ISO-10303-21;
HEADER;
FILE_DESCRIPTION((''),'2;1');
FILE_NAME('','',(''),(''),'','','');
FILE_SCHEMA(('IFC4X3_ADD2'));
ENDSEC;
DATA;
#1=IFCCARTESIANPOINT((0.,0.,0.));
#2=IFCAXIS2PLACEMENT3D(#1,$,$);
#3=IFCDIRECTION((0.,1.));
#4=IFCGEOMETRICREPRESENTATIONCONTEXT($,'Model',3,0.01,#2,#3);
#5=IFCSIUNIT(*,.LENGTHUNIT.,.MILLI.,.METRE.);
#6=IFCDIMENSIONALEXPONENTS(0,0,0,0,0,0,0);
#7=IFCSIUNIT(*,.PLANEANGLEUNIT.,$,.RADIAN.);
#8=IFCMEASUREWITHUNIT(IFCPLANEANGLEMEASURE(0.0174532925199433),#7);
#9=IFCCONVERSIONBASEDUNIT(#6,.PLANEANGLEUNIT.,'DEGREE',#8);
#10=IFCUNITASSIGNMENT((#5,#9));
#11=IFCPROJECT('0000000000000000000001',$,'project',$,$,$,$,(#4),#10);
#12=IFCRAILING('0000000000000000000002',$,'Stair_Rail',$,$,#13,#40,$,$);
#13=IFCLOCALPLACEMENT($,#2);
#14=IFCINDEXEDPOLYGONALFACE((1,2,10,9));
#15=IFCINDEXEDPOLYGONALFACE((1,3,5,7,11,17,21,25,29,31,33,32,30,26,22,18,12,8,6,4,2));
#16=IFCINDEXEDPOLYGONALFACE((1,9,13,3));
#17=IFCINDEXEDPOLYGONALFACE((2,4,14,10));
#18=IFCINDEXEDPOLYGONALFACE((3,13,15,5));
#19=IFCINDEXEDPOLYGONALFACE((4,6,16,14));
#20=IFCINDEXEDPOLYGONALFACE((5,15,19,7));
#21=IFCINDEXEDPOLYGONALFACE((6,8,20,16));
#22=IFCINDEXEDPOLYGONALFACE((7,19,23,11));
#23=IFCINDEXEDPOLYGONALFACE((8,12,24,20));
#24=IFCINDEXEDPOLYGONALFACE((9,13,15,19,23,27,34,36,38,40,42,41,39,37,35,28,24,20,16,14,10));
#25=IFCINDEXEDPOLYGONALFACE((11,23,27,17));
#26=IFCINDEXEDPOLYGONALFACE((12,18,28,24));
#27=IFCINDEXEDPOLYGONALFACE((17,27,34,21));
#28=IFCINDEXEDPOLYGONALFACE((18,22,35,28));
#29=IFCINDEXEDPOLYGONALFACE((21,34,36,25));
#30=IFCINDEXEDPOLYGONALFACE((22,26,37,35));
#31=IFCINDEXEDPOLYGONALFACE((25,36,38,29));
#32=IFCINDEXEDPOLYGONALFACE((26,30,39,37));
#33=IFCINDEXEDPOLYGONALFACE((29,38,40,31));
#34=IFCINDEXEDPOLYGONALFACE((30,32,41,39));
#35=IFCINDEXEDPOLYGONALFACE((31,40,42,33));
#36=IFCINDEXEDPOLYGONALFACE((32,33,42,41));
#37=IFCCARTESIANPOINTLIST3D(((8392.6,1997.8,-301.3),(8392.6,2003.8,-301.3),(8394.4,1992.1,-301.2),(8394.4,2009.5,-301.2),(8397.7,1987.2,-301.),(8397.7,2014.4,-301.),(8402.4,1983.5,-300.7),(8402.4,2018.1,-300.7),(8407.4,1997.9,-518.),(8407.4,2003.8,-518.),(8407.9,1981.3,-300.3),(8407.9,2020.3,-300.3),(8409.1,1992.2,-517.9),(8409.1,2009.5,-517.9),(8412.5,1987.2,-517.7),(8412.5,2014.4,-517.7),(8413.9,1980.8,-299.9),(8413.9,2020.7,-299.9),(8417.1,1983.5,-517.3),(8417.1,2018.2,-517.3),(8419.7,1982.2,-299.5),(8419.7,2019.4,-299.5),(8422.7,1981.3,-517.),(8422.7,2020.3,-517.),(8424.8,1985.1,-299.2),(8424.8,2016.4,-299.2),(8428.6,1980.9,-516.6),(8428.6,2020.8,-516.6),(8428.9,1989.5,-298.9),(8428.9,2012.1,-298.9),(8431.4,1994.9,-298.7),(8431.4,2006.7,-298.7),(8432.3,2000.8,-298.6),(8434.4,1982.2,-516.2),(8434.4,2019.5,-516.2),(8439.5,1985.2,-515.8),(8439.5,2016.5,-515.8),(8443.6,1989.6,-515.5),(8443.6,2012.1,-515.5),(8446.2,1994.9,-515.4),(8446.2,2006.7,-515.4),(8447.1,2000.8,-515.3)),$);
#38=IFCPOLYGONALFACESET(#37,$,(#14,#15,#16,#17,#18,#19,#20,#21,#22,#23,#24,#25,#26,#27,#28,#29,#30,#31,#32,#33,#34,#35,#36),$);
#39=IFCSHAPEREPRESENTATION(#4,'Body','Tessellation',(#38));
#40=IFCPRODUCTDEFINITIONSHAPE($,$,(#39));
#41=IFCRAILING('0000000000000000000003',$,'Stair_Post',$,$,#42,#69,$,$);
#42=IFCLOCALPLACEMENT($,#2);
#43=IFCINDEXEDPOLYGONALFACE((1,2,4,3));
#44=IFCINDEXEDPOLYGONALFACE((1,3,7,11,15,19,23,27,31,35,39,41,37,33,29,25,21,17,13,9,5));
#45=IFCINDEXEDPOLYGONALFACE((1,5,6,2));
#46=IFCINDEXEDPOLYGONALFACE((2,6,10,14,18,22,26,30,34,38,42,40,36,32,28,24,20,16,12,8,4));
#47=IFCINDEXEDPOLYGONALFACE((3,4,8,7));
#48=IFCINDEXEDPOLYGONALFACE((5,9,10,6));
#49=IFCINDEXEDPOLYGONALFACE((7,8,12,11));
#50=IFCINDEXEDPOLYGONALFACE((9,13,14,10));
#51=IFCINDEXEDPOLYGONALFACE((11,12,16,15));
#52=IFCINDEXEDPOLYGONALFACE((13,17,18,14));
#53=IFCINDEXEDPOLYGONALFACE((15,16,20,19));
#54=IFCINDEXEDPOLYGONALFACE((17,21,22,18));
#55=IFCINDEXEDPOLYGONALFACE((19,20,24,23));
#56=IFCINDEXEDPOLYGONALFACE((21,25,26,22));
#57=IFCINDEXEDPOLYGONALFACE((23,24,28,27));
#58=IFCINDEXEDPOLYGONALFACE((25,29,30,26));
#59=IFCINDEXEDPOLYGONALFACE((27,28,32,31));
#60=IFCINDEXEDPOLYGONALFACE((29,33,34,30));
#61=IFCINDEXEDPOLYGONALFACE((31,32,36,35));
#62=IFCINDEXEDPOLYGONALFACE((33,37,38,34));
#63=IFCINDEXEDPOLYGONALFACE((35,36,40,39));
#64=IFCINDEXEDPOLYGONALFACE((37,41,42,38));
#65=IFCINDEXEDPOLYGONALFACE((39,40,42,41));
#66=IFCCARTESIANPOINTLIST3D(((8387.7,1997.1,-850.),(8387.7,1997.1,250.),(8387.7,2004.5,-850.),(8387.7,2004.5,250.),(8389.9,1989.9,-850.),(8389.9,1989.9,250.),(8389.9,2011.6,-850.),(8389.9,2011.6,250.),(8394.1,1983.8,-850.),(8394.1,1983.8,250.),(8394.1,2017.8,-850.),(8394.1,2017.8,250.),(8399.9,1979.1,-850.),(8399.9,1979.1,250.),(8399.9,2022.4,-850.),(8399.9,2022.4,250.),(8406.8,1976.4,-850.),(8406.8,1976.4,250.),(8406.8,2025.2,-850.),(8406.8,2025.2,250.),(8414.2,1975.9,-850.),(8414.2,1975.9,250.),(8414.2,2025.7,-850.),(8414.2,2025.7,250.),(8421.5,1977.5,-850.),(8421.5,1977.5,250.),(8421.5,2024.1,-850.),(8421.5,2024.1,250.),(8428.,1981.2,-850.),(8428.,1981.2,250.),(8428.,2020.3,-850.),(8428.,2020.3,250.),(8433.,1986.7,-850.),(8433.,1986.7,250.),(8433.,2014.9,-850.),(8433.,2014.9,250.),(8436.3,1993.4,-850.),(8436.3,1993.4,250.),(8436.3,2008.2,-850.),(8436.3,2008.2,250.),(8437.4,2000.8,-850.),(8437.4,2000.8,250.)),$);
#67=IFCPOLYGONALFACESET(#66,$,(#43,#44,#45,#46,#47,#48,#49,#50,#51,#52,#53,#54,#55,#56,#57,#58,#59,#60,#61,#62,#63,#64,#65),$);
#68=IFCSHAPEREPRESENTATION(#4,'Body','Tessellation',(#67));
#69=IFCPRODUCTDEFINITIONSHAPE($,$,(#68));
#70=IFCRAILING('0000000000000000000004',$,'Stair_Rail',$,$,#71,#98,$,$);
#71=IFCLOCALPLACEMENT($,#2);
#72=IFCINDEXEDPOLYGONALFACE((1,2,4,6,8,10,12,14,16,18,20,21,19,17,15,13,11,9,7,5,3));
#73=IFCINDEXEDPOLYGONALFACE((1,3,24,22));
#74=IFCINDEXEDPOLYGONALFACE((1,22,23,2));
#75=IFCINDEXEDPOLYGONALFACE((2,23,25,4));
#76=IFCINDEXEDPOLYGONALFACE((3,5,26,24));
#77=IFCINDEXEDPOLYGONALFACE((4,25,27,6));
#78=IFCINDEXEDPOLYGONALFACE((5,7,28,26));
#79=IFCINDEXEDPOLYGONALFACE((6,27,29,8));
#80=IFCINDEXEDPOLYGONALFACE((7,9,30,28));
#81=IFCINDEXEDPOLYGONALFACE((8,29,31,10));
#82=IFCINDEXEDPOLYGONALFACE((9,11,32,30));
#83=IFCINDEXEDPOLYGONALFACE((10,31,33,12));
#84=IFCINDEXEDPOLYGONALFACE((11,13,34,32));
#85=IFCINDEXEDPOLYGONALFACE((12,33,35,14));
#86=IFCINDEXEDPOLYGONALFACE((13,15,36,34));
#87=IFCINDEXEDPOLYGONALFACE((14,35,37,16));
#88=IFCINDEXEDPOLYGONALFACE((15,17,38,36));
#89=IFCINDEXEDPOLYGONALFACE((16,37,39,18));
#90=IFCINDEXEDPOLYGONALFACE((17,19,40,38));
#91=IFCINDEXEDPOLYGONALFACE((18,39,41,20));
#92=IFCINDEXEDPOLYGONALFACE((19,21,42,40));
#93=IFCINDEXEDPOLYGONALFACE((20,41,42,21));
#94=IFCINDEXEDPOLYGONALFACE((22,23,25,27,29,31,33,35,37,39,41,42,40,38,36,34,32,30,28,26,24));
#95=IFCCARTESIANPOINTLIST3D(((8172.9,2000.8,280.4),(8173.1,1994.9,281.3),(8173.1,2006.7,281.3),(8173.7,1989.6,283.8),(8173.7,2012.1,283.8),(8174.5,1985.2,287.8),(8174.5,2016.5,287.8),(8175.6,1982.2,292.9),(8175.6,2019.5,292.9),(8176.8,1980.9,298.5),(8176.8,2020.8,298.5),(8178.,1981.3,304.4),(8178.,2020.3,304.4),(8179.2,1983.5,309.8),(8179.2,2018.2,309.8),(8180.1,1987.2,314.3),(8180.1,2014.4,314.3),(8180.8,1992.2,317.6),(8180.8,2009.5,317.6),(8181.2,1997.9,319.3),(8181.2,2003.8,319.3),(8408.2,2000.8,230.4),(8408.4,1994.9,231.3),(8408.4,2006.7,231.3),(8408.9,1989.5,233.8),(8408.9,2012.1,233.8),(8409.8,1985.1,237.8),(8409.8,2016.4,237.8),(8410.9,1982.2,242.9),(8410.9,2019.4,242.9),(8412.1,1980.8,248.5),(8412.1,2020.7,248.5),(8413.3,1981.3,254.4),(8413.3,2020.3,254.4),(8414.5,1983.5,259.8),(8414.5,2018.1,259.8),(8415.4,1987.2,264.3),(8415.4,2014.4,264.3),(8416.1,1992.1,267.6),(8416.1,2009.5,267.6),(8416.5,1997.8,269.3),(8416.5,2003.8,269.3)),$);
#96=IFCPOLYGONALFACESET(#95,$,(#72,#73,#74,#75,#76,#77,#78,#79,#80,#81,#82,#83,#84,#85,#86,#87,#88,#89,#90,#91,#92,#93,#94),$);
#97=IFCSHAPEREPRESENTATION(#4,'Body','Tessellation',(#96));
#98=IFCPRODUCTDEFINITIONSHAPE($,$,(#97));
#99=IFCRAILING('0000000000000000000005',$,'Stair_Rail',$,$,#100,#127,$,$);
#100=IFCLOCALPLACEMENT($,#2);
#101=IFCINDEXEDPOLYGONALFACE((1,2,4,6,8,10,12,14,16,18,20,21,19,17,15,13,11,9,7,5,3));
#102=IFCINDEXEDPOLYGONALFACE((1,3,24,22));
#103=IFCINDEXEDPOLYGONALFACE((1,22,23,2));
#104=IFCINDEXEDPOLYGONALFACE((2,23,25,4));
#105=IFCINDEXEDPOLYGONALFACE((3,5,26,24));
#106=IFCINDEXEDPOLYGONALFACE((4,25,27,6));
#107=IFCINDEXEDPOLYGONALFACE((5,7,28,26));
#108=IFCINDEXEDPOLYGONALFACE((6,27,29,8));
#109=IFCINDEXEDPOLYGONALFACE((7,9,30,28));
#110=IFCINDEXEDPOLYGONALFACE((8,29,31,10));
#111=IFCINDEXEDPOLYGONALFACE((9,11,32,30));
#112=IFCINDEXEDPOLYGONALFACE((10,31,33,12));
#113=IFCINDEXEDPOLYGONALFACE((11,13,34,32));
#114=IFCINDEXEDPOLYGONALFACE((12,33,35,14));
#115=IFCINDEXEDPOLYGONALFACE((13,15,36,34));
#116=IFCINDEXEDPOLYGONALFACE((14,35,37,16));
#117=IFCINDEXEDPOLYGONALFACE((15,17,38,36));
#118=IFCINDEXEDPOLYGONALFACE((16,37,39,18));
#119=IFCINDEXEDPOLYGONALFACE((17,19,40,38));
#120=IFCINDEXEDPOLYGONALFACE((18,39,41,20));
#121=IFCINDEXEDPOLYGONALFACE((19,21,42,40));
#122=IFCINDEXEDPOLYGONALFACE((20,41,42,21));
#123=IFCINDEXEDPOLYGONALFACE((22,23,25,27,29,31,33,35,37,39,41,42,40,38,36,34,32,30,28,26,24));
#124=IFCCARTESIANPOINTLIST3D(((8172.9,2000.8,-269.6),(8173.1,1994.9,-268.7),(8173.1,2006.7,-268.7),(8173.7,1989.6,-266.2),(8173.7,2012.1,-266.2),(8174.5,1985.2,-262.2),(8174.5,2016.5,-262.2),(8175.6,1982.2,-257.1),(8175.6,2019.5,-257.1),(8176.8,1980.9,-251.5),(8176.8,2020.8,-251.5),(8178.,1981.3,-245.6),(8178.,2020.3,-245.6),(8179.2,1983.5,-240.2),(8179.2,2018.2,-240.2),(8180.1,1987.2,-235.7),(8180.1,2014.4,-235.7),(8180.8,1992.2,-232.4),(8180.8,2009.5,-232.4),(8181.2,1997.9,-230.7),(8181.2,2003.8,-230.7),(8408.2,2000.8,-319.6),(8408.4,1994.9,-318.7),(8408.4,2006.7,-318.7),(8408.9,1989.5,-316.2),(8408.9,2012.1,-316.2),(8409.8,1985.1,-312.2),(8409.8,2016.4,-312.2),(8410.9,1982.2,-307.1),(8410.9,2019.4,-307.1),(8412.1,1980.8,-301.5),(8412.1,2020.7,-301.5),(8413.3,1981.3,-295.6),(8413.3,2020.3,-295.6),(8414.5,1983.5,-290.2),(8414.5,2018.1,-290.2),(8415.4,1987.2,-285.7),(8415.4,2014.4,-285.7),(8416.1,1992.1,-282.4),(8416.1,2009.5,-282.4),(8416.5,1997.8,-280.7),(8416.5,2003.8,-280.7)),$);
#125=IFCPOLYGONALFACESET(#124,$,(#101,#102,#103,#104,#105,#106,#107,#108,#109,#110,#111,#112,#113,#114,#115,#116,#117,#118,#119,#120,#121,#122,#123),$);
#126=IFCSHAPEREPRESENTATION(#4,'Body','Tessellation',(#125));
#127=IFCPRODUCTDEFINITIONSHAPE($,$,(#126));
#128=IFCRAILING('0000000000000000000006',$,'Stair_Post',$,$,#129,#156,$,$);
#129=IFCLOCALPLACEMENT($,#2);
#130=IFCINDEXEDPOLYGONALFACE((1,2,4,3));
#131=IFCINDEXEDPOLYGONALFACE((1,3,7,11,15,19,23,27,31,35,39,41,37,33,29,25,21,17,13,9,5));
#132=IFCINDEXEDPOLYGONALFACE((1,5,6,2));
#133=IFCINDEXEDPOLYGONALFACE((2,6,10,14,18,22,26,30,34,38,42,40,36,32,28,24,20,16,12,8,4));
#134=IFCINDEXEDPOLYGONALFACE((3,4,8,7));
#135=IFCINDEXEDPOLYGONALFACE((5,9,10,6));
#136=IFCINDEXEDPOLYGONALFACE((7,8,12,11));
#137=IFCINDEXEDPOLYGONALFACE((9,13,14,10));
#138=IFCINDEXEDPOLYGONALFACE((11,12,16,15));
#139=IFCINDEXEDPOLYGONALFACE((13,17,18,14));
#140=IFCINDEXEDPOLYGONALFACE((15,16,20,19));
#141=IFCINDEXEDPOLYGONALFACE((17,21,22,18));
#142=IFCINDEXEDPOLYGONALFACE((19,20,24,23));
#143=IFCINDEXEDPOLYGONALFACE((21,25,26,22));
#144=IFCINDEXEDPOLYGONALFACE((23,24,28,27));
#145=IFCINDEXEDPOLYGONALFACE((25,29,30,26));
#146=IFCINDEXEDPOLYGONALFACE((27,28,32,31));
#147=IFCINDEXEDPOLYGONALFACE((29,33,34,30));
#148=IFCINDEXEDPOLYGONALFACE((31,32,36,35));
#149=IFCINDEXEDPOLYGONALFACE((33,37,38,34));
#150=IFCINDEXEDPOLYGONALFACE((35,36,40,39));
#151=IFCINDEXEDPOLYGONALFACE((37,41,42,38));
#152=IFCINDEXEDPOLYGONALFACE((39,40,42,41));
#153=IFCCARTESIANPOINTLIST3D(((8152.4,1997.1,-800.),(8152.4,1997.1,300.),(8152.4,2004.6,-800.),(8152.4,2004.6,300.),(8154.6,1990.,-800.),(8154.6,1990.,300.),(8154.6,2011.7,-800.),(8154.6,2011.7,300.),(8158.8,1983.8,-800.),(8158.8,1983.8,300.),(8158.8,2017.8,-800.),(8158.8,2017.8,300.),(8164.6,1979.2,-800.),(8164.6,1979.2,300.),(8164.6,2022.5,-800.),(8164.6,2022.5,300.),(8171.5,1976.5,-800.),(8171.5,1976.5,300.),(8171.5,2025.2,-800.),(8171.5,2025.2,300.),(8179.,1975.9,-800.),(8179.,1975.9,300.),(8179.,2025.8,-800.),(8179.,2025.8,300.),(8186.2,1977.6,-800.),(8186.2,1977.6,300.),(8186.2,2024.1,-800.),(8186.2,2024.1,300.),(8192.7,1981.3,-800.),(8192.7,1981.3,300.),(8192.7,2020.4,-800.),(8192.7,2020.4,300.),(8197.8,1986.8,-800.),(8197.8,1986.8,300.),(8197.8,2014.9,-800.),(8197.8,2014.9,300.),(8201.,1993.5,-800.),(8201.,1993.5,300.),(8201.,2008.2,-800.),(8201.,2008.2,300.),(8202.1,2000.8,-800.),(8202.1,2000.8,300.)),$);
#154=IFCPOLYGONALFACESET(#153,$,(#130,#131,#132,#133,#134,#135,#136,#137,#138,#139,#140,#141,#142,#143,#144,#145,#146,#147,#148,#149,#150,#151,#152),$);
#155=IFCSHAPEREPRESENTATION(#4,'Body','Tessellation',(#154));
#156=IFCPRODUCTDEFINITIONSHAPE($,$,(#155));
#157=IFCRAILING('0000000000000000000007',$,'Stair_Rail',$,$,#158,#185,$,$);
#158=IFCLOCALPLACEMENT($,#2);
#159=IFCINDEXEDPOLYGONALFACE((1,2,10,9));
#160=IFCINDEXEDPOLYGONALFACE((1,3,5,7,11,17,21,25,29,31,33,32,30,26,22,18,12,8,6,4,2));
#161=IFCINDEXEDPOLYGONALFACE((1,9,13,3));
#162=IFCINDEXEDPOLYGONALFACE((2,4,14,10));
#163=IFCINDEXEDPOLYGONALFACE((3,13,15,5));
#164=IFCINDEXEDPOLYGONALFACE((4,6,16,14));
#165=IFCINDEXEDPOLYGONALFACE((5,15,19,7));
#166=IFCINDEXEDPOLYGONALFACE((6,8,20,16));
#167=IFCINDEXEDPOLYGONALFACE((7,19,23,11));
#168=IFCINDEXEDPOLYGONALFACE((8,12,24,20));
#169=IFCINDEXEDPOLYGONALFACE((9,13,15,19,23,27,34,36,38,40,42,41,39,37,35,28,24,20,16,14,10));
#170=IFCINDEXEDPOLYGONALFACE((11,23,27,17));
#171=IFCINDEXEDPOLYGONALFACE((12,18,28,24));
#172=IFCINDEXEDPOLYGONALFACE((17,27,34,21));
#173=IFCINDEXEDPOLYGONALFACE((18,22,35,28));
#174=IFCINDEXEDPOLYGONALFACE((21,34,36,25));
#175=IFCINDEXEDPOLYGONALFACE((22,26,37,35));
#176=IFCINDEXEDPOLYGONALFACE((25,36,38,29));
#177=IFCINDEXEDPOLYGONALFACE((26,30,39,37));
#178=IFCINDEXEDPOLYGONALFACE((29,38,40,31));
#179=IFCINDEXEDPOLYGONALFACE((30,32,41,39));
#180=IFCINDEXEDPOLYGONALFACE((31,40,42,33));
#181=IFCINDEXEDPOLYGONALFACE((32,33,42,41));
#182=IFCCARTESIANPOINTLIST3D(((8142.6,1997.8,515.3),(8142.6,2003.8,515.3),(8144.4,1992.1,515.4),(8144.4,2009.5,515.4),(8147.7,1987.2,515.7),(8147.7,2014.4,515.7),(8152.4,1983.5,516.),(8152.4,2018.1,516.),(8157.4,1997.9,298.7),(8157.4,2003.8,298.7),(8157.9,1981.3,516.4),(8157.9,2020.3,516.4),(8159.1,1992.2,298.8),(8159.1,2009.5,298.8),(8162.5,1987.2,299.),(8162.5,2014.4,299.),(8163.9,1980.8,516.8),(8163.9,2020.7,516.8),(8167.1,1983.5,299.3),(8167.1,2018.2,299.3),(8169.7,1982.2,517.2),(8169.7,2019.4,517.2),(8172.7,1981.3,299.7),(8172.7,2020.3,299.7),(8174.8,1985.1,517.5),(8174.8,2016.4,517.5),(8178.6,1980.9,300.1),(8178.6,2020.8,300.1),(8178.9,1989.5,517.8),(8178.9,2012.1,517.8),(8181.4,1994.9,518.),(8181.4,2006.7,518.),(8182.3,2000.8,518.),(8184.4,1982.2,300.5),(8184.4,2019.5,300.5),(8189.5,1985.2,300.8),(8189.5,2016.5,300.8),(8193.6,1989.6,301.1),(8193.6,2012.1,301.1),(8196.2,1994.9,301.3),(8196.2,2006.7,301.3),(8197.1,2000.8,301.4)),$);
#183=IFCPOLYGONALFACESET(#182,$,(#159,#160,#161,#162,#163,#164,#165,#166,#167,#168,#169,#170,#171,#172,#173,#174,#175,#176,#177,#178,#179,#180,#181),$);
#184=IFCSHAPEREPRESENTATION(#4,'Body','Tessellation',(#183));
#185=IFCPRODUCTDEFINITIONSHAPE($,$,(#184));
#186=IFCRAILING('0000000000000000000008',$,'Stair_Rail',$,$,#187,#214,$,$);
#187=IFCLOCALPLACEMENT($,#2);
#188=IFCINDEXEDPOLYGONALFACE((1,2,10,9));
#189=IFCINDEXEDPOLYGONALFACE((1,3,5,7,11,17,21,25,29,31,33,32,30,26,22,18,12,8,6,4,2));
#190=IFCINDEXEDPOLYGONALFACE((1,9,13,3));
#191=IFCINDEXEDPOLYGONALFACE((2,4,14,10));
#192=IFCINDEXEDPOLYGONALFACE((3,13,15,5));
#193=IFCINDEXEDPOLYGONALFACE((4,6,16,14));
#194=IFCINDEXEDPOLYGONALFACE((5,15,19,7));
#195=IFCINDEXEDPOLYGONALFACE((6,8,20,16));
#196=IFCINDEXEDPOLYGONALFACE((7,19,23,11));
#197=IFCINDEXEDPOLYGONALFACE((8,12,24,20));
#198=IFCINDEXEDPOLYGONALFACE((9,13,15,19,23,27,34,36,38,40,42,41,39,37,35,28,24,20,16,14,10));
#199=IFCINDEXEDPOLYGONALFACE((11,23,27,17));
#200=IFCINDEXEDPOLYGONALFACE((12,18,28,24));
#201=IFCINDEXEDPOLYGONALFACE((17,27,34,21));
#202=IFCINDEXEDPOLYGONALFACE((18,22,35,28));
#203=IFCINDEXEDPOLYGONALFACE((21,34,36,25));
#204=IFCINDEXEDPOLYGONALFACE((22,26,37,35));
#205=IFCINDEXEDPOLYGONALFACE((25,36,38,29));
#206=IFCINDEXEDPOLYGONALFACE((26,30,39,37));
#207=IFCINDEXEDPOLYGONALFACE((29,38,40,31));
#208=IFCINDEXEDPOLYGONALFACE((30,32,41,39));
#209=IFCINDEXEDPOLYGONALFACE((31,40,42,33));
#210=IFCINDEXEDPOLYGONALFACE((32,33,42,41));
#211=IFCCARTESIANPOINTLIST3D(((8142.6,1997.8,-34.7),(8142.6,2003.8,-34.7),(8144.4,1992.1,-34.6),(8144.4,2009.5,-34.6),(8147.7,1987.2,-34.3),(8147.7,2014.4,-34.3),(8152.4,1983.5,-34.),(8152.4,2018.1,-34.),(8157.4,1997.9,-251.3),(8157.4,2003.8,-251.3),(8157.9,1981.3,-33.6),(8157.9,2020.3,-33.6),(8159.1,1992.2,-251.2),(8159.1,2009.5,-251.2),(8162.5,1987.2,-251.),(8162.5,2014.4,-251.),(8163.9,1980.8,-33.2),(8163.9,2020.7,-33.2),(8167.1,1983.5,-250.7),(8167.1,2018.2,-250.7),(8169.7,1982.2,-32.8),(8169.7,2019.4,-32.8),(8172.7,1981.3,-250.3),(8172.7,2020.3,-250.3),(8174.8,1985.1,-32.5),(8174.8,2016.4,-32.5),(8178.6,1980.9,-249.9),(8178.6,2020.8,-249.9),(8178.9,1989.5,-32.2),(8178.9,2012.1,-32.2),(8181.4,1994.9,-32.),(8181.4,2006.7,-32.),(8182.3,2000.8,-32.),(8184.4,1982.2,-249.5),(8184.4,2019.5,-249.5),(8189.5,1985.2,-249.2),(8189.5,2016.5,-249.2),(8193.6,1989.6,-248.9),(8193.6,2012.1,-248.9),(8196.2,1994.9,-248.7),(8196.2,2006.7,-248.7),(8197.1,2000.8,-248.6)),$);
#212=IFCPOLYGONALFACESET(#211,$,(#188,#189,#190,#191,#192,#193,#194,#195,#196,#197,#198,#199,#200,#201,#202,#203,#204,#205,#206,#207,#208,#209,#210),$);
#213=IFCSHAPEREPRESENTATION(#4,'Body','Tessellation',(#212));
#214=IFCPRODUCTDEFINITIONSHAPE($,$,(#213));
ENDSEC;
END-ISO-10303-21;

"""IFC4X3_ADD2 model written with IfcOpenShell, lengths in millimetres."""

from ifc_helpers import new_model, entity, si_unit, converted_unit, direction, frame, origin, context, project, circle, extrude, element, save


model = new_model("IFC4X3_ADD2")

# Units and contexts
model_context = context("Model", 3, precision=0.01, world=origin(), true_north=direction((0.0, 1.0)))
ifc_project = project(units=[si_unit("LENGTHUNIT", "METRE", prefix="MILLI"), converted_unit("PLANEANGLEUNIT", "DEGREE", entity("IfcPlaneAngleMeasure", 0.0174532925199433), si_unit("PLANEANGLEUNIT", "RADIAN"), dimensions=[0, 0, 0, 0, 0, 0, 0])], contexts=[model_context])

# Railings
element("IfcRailing", 1, Name="Stair_Rail", context=model_context, shape_type="SweptSolid", body=[
    entity("IfcSweptDiskSolid", entity("IfcPolyline", [entity("IfcCartesianPoint", [8427.1, 2000.8, -516.7]), entity("IfcCartesianPoint", [8412.4, 2000.8, -300.0])]), 20.0),
])
element("IfcRailing", 2, Name="Stair_Post", context=model_context, shape_type="SweptSolid", body=[
    extrude(circle(Radius=25.0), frame((8412.4, 2000.8, -850.0)), (0.0, 0.0, 1.0), 1100.0),
])
element("IfcRailing", 3, Name="Stair_Rail", context=model_context, shape_type="SweptSolid", body=[
    entity("IfcSweptDiskSolid", entity("IfcPolyline", [entity("IfcCartesianPoint", [8412.4, 2000.8, 250.0]), entity("IfcCartesianPoint", [8177.1, 2000.8, 300.0])]), 20.0),
])
element("IfcRailing", 4, Name="Stair_Rail", context=model_context, shape_type="SweptSolid", body=[
    entity("IfcSweptDiskSolid", entity("IfcPolyline", [entity("IfcCartesianPoint", [8412.4, 2000.8, -300.0]), entity("IfcCartesianPoint", [8177.1, 2000.8, -250.0])]), 20.0),
])
element("IfcRailing", 5, Name="Stair_Post", context=model_context, shape_type="SweptSolid", body=[
    extrude(circle(Radius=25.0), frame((8177.1, 2000.8, -800.0)), (0.0, 0.0, 1.0), 1100.0),
])
element("IfcRailing", 6, Name="Stair_Rail", context=model_context, shape_type="SweptSolid", body=[
    entity("IfcSweptDiskSolid", entity("IfcPolyline", [entity("IfcCartesianPoint", [8177.1, 2000.8, 300.0]), entity("IfcCartesianPoint", [8162.4, 2000.8, 516.7])]), 20.0),
])
element("IfcRailing", 7, Name="Stair_Rail", context=model_context, shape_type="SweptSolid", body=[
    entity("IfcSweptDiskSolid", entity("IfcPolyline", [entity("IfcCartesianPoint", [8177.1, 2000.8, -250.0]), entity("IfcCartesianPoint", [8162.4, 2000.8, -33.3])]), 20.0),
])

save(model, "model.ifc")
